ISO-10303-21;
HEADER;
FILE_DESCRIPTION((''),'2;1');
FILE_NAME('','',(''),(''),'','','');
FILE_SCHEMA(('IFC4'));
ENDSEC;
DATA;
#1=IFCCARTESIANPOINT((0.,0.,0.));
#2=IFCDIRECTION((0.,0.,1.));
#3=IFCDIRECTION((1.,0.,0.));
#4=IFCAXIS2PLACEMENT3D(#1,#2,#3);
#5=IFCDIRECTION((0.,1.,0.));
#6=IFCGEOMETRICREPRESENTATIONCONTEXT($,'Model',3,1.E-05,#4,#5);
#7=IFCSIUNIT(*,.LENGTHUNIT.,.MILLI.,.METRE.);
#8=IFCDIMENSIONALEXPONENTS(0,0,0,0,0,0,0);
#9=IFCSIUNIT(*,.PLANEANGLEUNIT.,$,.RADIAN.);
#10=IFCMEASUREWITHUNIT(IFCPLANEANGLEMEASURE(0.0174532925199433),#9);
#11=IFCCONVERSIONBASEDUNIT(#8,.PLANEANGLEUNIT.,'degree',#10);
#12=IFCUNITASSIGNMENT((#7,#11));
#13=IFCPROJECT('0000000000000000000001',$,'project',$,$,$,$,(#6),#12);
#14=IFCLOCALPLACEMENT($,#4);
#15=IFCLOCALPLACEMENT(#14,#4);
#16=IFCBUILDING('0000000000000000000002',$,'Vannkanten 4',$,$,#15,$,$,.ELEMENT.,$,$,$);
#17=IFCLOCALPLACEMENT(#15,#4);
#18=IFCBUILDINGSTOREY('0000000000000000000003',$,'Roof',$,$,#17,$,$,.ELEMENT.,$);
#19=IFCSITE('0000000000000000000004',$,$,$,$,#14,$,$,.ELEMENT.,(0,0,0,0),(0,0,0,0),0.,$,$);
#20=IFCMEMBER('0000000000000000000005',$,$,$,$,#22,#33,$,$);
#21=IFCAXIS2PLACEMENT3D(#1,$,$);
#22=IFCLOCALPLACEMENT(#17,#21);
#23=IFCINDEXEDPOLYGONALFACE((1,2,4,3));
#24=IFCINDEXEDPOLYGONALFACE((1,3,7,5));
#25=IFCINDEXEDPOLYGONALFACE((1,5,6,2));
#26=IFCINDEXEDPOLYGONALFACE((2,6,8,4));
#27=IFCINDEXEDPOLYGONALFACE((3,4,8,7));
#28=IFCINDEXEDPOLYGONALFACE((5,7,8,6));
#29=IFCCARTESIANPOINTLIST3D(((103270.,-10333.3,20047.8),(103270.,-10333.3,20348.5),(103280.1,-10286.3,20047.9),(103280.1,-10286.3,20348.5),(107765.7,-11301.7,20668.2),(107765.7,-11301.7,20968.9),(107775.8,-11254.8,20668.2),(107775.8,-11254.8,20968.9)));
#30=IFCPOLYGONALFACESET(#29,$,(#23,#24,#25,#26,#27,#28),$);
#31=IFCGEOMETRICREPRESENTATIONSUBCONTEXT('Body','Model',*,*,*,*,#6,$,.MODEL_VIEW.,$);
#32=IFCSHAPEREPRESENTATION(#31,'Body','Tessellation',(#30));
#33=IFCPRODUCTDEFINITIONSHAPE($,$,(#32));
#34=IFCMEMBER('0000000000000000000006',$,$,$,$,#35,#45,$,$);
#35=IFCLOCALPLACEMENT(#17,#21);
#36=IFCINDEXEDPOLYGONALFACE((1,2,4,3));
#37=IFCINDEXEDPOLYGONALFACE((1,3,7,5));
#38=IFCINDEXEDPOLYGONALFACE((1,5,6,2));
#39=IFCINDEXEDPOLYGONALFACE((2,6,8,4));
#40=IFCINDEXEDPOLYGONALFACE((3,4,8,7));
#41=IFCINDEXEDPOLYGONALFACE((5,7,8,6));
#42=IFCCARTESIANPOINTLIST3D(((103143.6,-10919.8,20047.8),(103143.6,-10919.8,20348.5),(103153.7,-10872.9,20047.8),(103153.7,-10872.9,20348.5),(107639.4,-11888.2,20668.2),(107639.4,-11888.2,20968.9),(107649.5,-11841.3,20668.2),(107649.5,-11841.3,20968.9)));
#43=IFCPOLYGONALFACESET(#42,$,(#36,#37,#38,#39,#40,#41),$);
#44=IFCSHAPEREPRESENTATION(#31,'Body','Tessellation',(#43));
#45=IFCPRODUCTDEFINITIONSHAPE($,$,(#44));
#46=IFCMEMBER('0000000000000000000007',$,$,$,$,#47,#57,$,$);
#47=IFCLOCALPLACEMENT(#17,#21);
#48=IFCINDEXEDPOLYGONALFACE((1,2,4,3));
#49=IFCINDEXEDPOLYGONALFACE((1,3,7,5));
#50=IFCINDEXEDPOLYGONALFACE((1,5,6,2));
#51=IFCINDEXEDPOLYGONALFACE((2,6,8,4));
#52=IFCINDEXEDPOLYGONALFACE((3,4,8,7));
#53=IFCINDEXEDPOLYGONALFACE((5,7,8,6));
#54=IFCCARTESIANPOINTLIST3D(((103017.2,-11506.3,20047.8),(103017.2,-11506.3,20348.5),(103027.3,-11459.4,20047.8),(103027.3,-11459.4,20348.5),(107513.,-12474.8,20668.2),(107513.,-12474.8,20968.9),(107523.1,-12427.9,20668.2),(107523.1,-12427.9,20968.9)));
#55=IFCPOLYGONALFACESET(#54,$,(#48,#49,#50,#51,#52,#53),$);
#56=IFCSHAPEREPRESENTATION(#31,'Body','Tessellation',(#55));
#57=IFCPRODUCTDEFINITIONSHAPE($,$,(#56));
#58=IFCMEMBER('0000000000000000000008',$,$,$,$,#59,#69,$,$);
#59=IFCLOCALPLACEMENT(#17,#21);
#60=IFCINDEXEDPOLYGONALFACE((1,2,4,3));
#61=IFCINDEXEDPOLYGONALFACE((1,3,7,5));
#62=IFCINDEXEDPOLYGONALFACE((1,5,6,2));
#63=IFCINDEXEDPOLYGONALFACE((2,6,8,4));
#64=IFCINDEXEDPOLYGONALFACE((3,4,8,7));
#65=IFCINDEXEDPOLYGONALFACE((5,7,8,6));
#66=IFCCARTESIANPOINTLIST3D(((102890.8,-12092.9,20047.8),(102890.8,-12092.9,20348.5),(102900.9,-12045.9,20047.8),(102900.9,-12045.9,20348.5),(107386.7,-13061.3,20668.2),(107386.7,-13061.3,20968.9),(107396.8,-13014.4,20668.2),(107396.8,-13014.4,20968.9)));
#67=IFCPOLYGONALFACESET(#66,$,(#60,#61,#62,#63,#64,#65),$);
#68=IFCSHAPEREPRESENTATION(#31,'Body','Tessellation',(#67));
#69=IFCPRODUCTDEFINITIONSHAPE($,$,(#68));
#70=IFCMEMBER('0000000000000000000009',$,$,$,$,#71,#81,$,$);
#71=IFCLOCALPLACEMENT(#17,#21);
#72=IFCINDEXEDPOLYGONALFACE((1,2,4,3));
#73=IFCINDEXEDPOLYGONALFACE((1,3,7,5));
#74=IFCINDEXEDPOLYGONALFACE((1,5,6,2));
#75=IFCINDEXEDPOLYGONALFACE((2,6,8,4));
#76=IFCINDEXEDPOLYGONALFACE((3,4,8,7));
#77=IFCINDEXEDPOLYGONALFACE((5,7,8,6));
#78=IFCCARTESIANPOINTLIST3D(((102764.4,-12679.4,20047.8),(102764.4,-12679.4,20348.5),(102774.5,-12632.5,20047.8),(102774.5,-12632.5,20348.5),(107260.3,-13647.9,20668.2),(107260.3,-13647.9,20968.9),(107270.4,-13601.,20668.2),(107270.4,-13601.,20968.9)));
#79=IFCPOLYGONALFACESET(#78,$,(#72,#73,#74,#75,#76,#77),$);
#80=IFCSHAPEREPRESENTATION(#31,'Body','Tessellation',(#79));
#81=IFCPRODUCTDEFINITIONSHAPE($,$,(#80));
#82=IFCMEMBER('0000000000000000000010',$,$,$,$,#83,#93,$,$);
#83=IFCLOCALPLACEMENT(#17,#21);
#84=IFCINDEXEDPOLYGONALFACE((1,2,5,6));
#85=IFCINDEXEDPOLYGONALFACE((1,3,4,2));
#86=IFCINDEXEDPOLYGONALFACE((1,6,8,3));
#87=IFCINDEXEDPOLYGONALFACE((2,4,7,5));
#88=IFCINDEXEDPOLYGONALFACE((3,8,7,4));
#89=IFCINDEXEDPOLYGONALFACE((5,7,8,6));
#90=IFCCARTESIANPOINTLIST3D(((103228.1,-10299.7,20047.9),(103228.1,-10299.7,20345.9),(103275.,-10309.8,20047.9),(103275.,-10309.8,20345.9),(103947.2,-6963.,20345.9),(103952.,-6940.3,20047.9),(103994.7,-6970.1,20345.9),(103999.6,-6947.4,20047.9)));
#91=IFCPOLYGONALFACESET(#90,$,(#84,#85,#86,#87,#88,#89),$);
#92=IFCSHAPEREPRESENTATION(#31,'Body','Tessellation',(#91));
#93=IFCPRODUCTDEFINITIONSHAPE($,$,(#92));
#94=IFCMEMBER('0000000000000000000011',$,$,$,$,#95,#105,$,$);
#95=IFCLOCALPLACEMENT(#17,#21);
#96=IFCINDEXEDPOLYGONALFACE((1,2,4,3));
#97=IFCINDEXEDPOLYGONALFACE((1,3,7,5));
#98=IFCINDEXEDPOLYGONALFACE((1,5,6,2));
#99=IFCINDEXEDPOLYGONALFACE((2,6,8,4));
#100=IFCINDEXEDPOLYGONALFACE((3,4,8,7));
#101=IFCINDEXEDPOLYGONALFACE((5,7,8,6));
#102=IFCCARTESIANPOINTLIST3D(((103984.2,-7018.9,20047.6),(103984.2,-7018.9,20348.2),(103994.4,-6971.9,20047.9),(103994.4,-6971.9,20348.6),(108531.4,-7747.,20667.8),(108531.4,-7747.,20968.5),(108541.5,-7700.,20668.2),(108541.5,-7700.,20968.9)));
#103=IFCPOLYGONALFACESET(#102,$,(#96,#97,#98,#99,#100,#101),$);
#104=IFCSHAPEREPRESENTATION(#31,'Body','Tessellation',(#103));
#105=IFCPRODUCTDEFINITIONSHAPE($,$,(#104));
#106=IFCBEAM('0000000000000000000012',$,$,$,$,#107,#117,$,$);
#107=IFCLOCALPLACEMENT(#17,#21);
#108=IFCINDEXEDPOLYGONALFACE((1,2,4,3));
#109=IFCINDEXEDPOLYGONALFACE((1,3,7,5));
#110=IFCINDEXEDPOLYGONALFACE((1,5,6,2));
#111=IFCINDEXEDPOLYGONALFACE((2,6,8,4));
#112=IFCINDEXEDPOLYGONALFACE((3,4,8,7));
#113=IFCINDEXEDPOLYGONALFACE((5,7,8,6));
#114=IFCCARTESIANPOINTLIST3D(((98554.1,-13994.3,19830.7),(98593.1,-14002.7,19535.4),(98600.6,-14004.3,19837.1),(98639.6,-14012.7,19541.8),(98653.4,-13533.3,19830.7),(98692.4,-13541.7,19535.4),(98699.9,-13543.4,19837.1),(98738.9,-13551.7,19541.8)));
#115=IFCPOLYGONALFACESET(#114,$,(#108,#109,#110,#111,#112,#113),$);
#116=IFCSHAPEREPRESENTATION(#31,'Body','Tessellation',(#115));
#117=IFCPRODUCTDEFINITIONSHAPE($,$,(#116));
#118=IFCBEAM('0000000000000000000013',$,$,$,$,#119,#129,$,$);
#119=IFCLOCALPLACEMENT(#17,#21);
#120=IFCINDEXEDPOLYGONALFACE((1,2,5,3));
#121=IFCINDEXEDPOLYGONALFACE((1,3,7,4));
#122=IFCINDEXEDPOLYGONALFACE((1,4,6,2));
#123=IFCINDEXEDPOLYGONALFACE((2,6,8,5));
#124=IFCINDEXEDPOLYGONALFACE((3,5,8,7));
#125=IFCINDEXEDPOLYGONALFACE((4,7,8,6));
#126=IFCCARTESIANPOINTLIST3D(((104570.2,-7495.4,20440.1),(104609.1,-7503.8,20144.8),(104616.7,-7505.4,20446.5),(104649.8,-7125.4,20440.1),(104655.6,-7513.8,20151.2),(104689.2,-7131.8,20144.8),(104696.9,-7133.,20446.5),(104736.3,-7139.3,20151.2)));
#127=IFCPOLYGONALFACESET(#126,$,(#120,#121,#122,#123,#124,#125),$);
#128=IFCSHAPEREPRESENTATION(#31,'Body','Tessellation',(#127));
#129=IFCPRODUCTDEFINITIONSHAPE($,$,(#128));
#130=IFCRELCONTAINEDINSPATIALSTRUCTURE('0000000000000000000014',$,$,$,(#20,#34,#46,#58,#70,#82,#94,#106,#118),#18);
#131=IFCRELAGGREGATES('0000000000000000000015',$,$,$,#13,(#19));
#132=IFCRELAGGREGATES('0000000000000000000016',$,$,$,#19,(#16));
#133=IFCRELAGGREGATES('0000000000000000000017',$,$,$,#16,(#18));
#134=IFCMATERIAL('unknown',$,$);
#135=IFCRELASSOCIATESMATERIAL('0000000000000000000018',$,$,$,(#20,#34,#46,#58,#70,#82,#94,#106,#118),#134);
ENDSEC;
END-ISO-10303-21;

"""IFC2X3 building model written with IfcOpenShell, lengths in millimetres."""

from ifc_helpers import new_model, entity, si_unit, converted_unit, direction, frame, origin_with_axes, place, context, subcontext, project, spatial, polyline, segment, composite_curve, outline, extrude, clip, halfspace, material, element, save


model = new_model("IFC2X3")

# Units and contexts
model_context = context("Model", 3, precision=1e-05, world=origin_with_axes(), true_north=direction((0.0, 1.0, 0.0)))
body_context = subcontext(model_context, "Body", "Model", "MODEL_VIEW")
ifc_project = project(units=[si_unit("LENGTHUNIT", "METRE", prefix="MILLI"), converted_unit("PLANEANGLEUNIT", "degree", entity("IfcPlaneAngleMeasure", 0.0174532925199433), si_unit("PLANEANGLEUNIT", "RADIAN"), dimensions=[0, 0, 0, 0, 0, 0, 0])], contexts=[model_context])

# Site, building, storey
site_placement = place(None, origin_with_axes())
site = spatial("IfcSite", under=ifc_project, at=site_placement, CompositionType="ELEMENT", RefLatitude=(0, 0, 0, 0), RefLongitude=(0, 0, 0, 0), RefElevation=0.0)
building_placement = place(site_placement, origin_with_axes())
building = spatial("IfcBuilding", under=site, at=building_placement, Name="Vannkanten 4", CompositionType="ELEMENT")
storey_placement = place(building_placement, origin_with_axes())
storey = spatial("IfcBuildingStorey", under=building, at=storey_placement, Name="Roof", CompositionType="ELEMENT")

# Shared definitions
ifc_material = material(Name="unknown")

# Members
member_1_placement = place(storey_placement, frame((103275.0, -10309.8, 20198.2), z_axis=(0.968803, -0.208692, 0.133675), x_axis=(0.210582, 0.977576, 0.0)))
element("IfcMember", 1, at=member_1_placement, inside=storey, material=ifc_material, context=body_context, shape_type="Clipping", body=[
    clip(clip(extrude(outline(composite_curve([segment(polyline([(-24.0, -149.0), (-24.0, 149.0), (24.0, 149.0), (24.0, -149.0), (-24.0, -149.0)]), True, "CONTINUOUS")], self_intersect=False)), frame((0.0, 0.0, -2360.4), z_axis=(0.0, 0.0, 1.0), x_axis=(1.0, 0.0, 0.0)), (0.0, 0.0, 1.0), 9361.4), halfspace(frame((-24.0, 149.0, 20.1), z_axis=(-0.000083, -0.133675, 0.991025), x_axis=(0.0, 0.991025, 0.133675)), True)), halfspace(frame((24.0, 149.0, 4660.6), z_axis=(0.0, 0.133675, -0.991025), x_axis=(0.0, -0.991025, -0.133675)), True)),
])
member_2_placement = place(storey_placement, frame((103148.6, -10896.3, 20198.2), z_axis=(0.968803, -0.208692, 0.133675), x_axis=(0.210582, 0.977576, 0.0)))
element("IfcMember", 2, at=member_2_placement, inside=storey, material=ifc_material, context=body_context, shape_type="Clipping", body=[
    clip(clip(extrude(outline(composite_curve([segment(polyline([(-24.0, -149.0), (-24.0, 149.0), (24.0, 149.0), (24.0, -149.0), (-24.0, -149.0)]), True, "CONTINUOUS")], self_intersect=False)), frame((0.0, 0.0, -2360.5), z_axis=(0.0, 0.0, 1.0), x_axis=(1.0, 0.0, 0.0)), (0.0, 0.0, 1.0), 9361.5), halfspace(frame((-24.0, 149.0, 20.1), z_axis=(-0.000083, -0.133675, 0.991025), x_axis=(0.0, 0.991025, 0.133675)), True)), halfspace(frame((24.0, 149.0, 4660.6), z_axis=(0.0, 0.133675, -0.991025), x_axis=(0.0, -0.991025, -0.133675)), True)),
])
member_3_placement = place(storey_placement, frame((103022.2, -11482.9, 20198.2), z_axis=(0.968803, -0.208692, 0.133675), x_axis=(0.210582, 0.977576, 0.0)))
element("IfcMember", 3, at=member_3_placement, inside=storey, material=ifc_material, context=body_context, shape_type="Clipping", body=[
    clip(clip(extrude(outline(composite_curve([segment(polyline([(-24.0, -149.0), (-24.0, 149.0), (24.0, 149.0), (24.0, -149.0), (-24.0, -149.0)]), True, "CONTINUOUS")], self_intersect=False)), frame((0.0, 0.0, -2360.5), z_axis=(0.0, 0.0, 1.0), x_axis=(1.0, 0.0, 0.0)), (0.0, 0.0, 1.0), 9361.6), halfspace(frame((-24.0, 149.0, 20.1), z_axis=(-0.000083, -0.133675, 0.991025), x_axis=(0.0, 0.991025, 0.133675)), True)), halfspace(frame((24.0, 149.0, 4660.7), z_axis=(0.0, 0.133675, -0.991025), x_axis=(0.0, -0.991025, -0.133675)), True)),
])
member_4_placement = place(storey_placement, frame((102895.8, -12069.4, 20198.2), z_axis=(0.968803, -0.208692, 0.133675), x_axis=(0.210582, 0.977576, 0.0)))
element("IfcMember", 4, at=member_4_placement, inside=storey, material=ifc_material, context=body_context, shape_type="Clipping", body=[
    clip(clip(extrude(outline(composite_curve([segment(polyline([(-24.0, -149.0), (-24.0, 149.0), (24.0, 149.0), (24.0, -149.0), (-24.0, -149.0)]), True, "CONTINUOUS")], self_intersect=False)), frame((0.0, 0.0, -2360.5), z_axis=(0.0, 0.0, 1.0), x_axis=(1.0, 0.0, 0.0)), (0.0, 0.0, 1.0), 9361.7), halfspace(frame((-24.0, 149.0, 20.1), z_axis=(-0.000083, -0.133675, 0.991025), x_axis=(0.0, 0.991025, 0.133675)), True)), halfspace(frame((24.0, 149.0, 4660.7), z_axis=(0.0, 0.133675, -0.991025), x_axis=(0.0, -0.991025, -0.133675)), True)),
])
member_5_placement = place(storey_placement, frame((102769.4, -12655.9, 20198.2), z_axis=(0.968803, -0.208692, 0.133675), x_axis=(0.210582, 0.977576, 0.0)))
element("IfcMember", 5, at=member_5_placement, inside=storey, material=ifc_material, context=body_context, shape_type="Clipping", body=[
    clip(clip(extrude(outline(composite_curve([segment(polyline([(-24.0, -149.0), (-24.0, 149.0), (24.0, 149.0), (24.0, -149.0), (-24.0, -149.0)]), True, "CONTINUOUS")], self_intersect=False)), frame((0.0, 0.0, -2360.5), z_axis=(0.0, 0.0, 1.0), x_axis=(1.0, 0.0, 0.0)), (0.0, 0.0, 1.0), 9361.8), halfspace(frame((-24.0, 149.0, 20.1), z_axis=(-0.000083, -0.133675, 0.991025), x_axis=(0.0, 0.991025, 0.133675)), True)), halfspace(frame((24.0, 149.0, 4660.8), z_axis=(0.0, 0.133675, -0.991025), x_axis=(0.0, -0.991025, -0.133675)), True)),
])
member_6_placement = place(storey_placement, frame((103973.4, -6955.2, 20196.9), z_axis=(-0.210663, -0.977559, -0.000011), x_axis=(0.977559, -0.210663, 0.0)))
element("IfcMember", 6, at=member_6_placement, inside=storey, material=ifc_material, context=body_context, shape_type="Clipping", body=[
    clip(extrude(outline(composite_curve([segment(polyline([(-24.0, -149.0), (-24.0, 149.0), (24.0, 149.0), (24.0, -149.0), (-24.0, -149.0)]), True, "CONTINUOUS")], self_intersect=False)), frame((0.0, 0.0, -1733.0), z_axis=(0.0, 0.0, 1.0), x_axis=(1.0, 0.0, 0.0)), (0.0, 0.0, 1.0), 5159.4), halfspace(frame((-24.0, 149.0, 13.2), z_axis=(0.064639, -0.077465, 0.994897), x_axis=(0.0, 0.996982, 0.077628)), True)),
])
member_7_placement = place(storey_placement, frame((103989.3, -6995.4, 20198.1), z_axis=(0.978583, -0.156701, 0.133488), x_axis=(0.158117, 0.98742, 0.0)))
element("IfcMember", 7, at=member_7_placement, inside=storey, material=ifc_material, context=body_context, shape_type="Clipping", body=[
    clip(clip(extrude(outline(composite_curve([segment(polyline([(-24.0, -149.0), (-24.0, 149.0), (24.0, 149.0), (24.0, -149.0), (-24.0, -149.0)]), True, "CONTINUOUS")], self_intersect=False)), frame((0.0, 0.0, -2366.1), z_axis=(0.0, 0.0, 1.0), x_axis=(1.0, 0.0, 0.0)), (0.0, 0.0, 1.0), 9378.9), halfspace(frame((-24.0, 149.0, 18.8), z_axis=(-0.053445, -0.133297, 0.989634), x_axis=(0.0, 0.99105, 0.133488)), True)), halfspace(frame((24.0, 149.0, 4668.1), z_axis=(0.053362, 0.133298, -0.989638), x_axis=(0.0, -0.99105, -0.133488)), True)),
])

# Beams
beam_1_placement = place(storey_placement, frame((98596.9, -14003.5, 19686.2), z_axis=(0.210582, 0.977576, 0.0), x_axis=(-0.968803, 0.208692, -0.133675)))
element("IfcBeam", 8, at=beam_1_placement, inside=storey, material=ifc_material, context=body_context, shape_type="SweptSolid", body=[
    extrude(outline(composite_curve([segment(polyline([(-24.0, -149.0), (-24.0, 149.0), (24.0, 149.0), (24.0, -149.0), (-24.0, -149.0)]), True, "CONTINUOUS")], self_intersect=False)), frame((0.0, 0.0, 0.0), z_axis=(0.0, 0.0, 1.0), x_axis=(1.0, 0.0, 0.0)), (0.0, 0.0, 1.0), 471.5),
])
beam_2_placement = place(storey_placement, frame((104612.9, -7504.6, 20295.6), z_axis=(0.210582, 0.977576, 0.0), x_axis=(-0.968803, 0.208692, -0.133675)))
element("IfcBeam", 9, at=beam_2_placement, inside=storey, material=ifc_material, context=body_context, shape_type="Clipping", body=[
    clip(extrude(outline(composite_curve([segment(polyline([(-24.0, -149.0), (-24.0, 149.0), (24.0, 149.0), (24.0, -149.0), (-24.0, -149.0)]), True, "CONTINUOUS")], self_intersect=False)), frame((0.0, 0.0, 0.0), z_axis=(0.0, 0.0, 1.0), x_axis=(1.0, 0.0, 0.0)), (0.0, 0.0, 1.0), 574.7), halfspace(frame((-24.0, -149.0, 383.1), z_axis=(-0.052883, -0.007133, -0.998575), x_axis=(-0.998601, 0.0, 0.052884)), True)),
])

save(model, "model.ifc")
